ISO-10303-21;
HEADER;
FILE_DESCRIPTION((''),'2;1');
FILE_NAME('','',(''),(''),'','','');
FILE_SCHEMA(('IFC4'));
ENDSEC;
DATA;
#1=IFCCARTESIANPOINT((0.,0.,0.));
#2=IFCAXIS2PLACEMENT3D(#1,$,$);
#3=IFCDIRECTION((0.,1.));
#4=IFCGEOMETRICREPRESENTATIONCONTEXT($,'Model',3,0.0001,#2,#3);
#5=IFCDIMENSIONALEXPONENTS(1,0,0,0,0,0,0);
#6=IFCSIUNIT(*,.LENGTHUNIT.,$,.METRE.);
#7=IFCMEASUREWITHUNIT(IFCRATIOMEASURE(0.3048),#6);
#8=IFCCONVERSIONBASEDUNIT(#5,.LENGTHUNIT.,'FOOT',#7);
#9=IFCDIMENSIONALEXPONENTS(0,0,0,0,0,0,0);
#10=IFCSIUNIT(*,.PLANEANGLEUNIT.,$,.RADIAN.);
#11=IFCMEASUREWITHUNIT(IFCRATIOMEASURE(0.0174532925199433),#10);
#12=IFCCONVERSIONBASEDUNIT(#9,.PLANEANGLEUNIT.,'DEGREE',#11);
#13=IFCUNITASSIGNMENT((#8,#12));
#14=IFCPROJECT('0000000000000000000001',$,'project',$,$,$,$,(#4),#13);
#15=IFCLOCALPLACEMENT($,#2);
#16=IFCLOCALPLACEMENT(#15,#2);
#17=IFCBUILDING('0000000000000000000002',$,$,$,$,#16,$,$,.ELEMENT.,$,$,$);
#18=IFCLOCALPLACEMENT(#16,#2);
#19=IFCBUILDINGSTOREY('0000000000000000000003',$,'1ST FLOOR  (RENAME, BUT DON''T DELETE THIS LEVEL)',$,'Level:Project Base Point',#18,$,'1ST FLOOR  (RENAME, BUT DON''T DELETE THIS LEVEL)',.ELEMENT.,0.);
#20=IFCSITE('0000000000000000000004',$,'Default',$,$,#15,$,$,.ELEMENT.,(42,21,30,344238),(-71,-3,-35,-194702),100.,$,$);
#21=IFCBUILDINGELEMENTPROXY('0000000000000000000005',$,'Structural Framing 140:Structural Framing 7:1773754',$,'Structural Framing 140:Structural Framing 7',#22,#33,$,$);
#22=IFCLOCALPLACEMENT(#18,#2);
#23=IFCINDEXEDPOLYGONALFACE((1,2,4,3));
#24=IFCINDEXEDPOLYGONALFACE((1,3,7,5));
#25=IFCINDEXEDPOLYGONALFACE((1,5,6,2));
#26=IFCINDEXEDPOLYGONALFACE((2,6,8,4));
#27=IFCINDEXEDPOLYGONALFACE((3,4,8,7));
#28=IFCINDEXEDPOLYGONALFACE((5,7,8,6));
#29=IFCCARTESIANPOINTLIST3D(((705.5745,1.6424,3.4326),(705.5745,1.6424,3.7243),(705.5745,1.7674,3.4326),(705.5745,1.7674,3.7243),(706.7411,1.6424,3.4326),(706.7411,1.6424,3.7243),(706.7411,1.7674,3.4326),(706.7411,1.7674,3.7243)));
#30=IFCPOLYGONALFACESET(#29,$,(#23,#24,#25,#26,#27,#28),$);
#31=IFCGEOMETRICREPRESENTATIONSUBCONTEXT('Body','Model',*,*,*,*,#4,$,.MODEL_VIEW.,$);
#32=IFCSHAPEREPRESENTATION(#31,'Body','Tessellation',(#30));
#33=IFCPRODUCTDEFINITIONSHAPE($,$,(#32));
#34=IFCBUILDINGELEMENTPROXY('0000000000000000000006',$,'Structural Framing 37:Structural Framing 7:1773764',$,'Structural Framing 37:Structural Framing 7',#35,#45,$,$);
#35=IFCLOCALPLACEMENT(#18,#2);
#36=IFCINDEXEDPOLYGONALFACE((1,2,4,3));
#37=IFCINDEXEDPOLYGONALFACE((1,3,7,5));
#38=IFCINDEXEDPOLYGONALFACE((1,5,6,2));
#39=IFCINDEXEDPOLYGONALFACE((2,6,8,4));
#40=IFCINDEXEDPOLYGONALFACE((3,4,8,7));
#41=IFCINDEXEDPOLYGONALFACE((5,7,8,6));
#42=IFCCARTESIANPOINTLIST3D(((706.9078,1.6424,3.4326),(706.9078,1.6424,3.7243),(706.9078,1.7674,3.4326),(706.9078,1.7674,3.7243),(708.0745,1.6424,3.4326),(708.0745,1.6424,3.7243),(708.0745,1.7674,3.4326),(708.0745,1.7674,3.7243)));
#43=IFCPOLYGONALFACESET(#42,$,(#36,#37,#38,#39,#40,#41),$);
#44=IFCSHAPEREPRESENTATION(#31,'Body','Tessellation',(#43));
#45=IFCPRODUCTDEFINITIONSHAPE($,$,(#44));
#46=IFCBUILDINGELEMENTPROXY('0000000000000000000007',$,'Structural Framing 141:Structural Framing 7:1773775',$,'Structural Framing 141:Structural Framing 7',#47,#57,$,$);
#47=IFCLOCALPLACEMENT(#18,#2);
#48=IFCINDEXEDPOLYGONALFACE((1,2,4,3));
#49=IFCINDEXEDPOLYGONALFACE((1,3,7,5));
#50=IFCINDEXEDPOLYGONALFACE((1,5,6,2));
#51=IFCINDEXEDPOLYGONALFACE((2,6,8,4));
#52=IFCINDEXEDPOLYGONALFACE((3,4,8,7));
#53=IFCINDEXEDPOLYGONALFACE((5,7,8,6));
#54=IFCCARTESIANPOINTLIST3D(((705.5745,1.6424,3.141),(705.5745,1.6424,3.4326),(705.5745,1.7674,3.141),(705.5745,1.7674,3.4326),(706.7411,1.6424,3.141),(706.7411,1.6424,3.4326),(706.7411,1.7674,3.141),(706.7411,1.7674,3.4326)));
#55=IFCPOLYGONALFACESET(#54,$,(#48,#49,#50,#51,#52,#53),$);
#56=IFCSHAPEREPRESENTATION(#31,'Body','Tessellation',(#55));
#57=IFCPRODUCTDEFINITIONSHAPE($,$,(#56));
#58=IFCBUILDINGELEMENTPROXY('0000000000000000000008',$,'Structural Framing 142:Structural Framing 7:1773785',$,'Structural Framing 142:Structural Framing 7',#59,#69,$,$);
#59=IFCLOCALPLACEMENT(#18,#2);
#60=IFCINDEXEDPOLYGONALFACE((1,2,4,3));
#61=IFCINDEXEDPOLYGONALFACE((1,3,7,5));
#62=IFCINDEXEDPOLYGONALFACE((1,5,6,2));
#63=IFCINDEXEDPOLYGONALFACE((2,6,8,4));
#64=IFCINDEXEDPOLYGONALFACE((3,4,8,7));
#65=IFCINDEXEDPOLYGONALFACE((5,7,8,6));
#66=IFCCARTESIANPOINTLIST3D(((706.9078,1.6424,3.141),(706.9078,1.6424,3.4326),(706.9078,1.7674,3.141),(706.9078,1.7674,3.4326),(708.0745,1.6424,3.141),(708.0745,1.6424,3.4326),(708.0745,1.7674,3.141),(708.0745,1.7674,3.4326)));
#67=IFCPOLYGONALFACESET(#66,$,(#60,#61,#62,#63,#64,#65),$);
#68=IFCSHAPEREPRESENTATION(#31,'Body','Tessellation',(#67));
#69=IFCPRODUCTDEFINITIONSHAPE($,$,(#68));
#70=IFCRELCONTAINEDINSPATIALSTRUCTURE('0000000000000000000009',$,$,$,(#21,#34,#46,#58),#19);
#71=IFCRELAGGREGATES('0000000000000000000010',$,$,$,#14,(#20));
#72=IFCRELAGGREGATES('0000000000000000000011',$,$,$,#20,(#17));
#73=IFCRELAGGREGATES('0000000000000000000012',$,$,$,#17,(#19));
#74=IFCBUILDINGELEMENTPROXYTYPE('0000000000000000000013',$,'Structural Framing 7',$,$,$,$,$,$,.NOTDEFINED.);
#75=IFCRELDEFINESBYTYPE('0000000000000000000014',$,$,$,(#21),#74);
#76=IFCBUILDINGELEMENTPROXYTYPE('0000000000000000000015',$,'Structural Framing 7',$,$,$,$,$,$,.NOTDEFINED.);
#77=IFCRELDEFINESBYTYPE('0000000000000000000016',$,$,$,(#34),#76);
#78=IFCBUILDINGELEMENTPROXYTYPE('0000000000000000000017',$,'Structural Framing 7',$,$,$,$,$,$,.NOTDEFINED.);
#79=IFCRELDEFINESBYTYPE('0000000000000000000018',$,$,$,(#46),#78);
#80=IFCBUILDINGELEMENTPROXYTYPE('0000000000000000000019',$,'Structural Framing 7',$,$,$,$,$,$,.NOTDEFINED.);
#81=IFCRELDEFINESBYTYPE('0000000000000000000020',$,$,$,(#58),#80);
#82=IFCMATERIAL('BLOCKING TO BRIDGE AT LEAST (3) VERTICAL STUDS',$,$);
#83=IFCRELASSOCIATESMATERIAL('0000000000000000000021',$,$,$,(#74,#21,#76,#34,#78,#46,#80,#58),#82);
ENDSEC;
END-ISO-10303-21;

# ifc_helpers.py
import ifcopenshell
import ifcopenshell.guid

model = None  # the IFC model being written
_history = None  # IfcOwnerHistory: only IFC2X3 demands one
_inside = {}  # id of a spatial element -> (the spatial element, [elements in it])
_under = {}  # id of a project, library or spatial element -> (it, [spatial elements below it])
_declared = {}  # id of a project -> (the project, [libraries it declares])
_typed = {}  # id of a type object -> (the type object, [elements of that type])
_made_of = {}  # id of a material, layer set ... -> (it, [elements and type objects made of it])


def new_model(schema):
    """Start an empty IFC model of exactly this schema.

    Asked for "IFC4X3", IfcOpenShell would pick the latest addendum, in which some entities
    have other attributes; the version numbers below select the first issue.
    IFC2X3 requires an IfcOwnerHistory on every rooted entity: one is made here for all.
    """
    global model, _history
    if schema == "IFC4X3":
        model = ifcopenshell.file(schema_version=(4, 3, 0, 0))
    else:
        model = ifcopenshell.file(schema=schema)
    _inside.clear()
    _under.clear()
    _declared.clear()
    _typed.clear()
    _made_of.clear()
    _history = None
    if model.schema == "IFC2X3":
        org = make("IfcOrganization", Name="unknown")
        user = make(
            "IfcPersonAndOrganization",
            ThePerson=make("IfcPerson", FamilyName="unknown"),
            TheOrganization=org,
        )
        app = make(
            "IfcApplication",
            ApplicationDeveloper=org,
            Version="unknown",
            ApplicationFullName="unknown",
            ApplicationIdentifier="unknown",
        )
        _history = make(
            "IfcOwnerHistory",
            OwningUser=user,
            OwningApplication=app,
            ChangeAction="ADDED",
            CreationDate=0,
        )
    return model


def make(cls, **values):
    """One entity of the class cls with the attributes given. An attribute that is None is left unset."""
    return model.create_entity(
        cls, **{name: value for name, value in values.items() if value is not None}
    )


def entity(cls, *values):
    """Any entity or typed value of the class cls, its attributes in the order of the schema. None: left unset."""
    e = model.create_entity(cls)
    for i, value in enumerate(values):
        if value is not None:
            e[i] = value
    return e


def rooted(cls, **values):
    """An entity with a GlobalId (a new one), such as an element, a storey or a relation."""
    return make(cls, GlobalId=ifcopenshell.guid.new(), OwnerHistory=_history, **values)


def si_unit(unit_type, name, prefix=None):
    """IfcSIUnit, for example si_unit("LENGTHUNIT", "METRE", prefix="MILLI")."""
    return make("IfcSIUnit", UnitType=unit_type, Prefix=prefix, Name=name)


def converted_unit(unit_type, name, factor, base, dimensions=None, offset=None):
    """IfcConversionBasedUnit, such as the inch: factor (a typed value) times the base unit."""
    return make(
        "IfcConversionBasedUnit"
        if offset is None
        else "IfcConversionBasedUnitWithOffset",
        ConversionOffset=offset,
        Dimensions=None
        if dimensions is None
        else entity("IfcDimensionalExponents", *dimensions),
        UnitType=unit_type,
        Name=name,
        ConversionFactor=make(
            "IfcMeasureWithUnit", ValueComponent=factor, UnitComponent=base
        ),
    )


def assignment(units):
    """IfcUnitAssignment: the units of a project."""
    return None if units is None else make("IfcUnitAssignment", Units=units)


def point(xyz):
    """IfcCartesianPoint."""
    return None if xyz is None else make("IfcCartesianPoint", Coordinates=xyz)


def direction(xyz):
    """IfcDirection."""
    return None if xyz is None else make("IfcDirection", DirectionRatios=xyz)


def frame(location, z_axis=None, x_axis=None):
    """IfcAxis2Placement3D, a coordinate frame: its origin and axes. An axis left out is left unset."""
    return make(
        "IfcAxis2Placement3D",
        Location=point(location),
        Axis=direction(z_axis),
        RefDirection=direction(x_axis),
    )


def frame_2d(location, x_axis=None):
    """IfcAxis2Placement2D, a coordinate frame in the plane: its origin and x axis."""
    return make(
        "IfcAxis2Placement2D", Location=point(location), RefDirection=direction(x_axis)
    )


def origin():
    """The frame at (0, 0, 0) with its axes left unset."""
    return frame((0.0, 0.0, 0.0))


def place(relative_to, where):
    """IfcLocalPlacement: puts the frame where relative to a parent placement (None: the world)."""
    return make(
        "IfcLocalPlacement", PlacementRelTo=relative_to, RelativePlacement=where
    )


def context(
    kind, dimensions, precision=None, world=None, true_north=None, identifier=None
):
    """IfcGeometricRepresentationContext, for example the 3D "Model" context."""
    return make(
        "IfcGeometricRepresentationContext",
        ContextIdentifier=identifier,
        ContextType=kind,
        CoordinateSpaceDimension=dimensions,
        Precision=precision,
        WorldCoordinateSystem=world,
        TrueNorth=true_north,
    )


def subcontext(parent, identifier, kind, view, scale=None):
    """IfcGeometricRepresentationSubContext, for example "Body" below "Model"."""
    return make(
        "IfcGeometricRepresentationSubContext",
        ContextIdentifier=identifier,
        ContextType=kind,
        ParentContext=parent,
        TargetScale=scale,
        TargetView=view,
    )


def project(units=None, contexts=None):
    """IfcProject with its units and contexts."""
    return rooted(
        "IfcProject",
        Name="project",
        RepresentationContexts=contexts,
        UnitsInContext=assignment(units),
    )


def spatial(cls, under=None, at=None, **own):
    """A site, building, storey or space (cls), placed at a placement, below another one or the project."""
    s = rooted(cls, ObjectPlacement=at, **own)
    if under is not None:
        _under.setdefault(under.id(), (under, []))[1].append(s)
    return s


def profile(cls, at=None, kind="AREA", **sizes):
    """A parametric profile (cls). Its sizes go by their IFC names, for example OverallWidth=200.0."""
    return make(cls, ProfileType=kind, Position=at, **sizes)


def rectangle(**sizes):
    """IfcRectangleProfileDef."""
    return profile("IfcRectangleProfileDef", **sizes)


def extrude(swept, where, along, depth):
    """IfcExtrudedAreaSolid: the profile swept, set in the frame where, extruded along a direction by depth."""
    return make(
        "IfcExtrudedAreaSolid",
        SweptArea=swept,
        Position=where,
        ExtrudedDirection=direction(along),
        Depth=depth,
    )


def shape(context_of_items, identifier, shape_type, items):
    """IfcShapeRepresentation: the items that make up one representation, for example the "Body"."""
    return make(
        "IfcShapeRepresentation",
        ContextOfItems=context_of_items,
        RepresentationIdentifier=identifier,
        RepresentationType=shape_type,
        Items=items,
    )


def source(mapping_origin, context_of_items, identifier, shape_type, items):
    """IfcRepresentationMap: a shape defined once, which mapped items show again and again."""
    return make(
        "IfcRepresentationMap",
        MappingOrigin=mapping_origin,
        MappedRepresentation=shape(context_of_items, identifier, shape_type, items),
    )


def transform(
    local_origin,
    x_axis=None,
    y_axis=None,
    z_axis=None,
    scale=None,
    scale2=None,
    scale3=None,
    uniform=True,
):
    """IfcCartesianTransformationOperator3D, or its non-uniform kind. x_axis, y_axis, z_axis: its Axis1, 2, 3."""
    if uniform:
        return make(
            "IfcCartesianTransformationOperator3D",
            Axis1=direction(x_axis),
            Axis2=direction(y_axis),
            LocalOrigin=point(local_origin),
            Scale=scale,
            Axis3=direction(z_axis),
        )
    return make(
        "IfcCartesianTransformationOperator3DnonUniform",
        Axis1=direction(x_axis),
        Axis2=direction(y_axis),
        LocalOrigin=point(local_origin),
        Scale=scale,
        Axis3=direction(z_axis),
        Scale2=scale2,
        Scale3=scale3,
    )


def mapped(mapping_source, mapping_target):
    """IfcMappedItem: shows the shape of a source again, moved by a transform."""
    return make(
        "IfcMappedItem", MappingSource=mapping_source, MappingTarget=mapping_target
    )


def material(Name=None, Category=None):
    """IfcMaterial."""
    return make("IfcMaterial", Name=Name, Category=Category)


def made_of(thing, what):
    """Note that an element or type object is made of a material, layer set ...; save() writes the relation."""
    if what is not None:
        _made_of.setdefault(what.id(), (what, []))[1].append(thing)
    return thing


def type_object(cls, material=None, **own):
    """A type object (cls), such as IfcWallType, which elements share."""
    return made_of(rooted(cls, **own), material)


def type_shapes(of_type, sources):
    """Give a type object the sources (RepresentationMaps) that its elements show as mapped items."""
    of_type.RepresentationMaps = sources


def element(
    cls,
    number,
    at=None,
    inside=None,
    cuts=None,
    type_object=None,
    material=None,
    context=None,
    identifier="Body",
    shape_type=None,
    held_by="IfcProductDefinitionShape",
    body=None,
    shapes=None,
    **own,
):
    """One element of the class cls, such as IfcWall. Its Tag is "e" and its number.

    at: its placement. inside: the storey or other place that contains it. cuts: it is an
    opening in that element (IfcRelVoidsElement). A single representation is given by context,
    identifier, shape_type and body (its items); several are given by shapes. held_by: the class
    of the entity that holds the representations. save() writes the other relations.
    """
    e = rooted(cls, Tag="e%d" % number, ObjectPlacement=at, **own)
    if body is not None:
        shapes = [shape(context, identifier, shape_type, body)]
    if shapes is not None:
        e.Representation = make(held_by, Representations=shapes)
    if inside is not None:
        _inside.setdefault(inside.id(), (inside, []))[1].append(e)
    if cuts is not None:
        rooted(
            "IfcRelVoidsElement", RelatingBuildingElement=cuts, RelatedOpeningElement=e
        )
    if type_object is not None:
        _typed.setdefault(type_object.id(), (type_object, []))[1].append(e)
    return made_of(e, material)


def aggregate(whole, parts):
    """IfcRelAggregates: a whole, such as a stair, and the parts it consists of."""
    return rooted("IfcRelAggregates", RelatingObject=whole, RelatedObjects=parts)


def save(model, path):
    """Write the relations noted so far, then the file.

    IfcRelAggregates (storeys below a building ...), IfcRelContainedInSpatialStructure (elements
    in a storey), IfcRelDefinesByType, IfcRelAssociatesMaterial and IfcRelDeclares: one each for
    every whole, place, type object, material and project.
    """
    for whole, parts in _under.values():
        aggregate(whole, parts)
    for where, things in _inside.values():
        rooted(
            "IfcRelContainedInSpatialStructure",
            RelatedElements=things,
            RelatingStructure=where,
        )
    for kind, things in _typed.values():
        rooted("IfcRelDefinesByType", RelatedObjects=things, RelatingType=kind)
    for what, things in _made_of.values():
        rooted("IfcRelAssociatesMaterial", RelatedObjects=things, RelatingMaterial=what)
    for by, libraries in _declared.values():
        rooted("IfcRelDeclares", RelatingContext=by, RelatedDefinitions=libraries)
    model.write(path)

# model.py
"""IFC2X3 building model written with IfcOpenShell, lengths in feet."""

from ifc_helpers import new_model, entity, si_unit, converted_unit, direction, frame, frame_2d, origin, place, context, subcontext, project, spatial, rectangle, extrude, source, transform, mapped, material, type_object, type_shapes, element, save


model = new_model("IFC2X3")

# Units and contexts
model_context = context("Model", 3, precision=0.0001, world=origin(), true_north=direction((0.0, 1.0)))
body_context = subcontext(model_context, "Body", "Model", "MODEL_VIEW")
ifc_project = project(units=[converted_unit("LENGTHUNIT", "FOOT", entity("IfcRatioMeasure", 0.3048), si_unit("LENGTHUNIT", "METRE"), dimensions=[1, 0, 0, 0, 0, 0, 0]), converted_unit("PLANEANGLEUNIT", "DEGREE", entity("IfcRatioMeasure", 0.0174532925199433), si_unit("PLANEANGLEUNIT", "RADIAN"), dimensions=[0, 0, 0, 0, 0, 0, 0])], contexts=[model_context])

# Site, building, storey
site_placement = place(None, origin())
site = spatial("IfcSite", under=ifc_project, at=site_placement, Name="Default", CompositionType="ELEMENT", RefLatitude=(42, 21, 30, 344238), RefLongitude=(-71, -3, -35, -194702), RefElevation=100.0)
building_placement = place(site_placement, origin())
building = spatial("IfcBuilding", under=site, at=building_placement, CompositionType="ELEMENT")
storey_placement = place(building_placement, origin())
storey = spatial("IfcBuildingStorey", under=building, at=storey_placement, Name="1ST FLOOR  (RENAME, BUT DON'T DELETE THIS LEVEL)", ObjectType="Level:Project Base Point", LongName="1ST FLOOR  (RENAME, BUT DON'T DELETE THIS LEVEL)", CompositionType="ELEMENT", Elevation=0.0)

# Building element proxies
ifc_material_1 = material(Name="BLOCKING TO BRIDGE AT LEAST (3) VERTICAL STUDS")
building_element_proxy_type_1 = type_object("IfcBuildingElementProxyType", Name="Structural Framing 7", PredefinedType="NOTDEFINED", material=ifc_material_1)
shared_shape_1 = source(origin(), body_context, "Body", "SweptSolid", [
    extrude(rectangle(XDim=1.1667, YDim=0.125, at=frame_2d((0.0, 0.0), x_axis=(1.0, 0.0))), frame((0.5833, 0.0625, 0.0), z_axis=(0.0, 0.0, 1.0), x_axis=(-1.0, 0.0, 0.0)), (0.0, 0.0, 1.0), 0.2917),
])
type_shapes(building_element_proxy_type_1, [shared_shape_1])
proxy_1_placement = place(storey_placement, frame((705.5745, 1.6424, 3.4326)))
element("IfcBuildingElementProxy", 1, at=proxy_1_placement, inside=storey, type_object=building_element_proxy_type_1, material=ifc_material_1, Name="Structural Framing 140:Structural Framing 7:1773754", ObjectType="Structural Framing 140:Structural Framing 7", context=body_context, shape_type="MappedRepresentation", body=[
    mapped(shared_shape_1, transform((0.0, 0.0, 0.0), scale=1.0)),
])
building_element_proxy_type_2 = type_object("IfcBuildingElementProxyType", Name="Structural Framing 7", PredefinedType="NOTDEFINED", material=ifc_material_1)
shared_shape_2 = source(origin(), body_context, "Body", "SweptSolid", [
    extrude(rectangle(XDim=1.1667, YDim=0.125, at=frame_2d((0.0, 0.0), x_axis=(1.0, 0.0))), frame((0.5833, 0.0625, 0.0), z_axis=(0.0, 0.0, 1.0), x_axis=(-1.0, 0.0, 0.0)), (0.0, 0.0, 1.0), 0.2917),
])
type_shapes(building_element_proxy_type_2, [shared_shape_2])
proxy_2_placement = place(storey_placement, frame((706.9078, 1.6424, 3.4326)))
element("IfcBuildingElementProxy", 2, at=proxy_2_placement, inside=storey, type_object=building_element_proxy_type_2, material=ifc_material_1, Name="Structural Framing 37:Structural Framing 7:1773764", ObjectType="Structural Framing 37:Structural Framing 7", context=body_context, shape_type="MappedRepresentation", body=[
    mapped(shared_shape_2, transform((0.0, 0.0, 0.0), scale=1.0)),
])
building_element_proxy_type_3 = type_object("IfcBuildingElementProxyType", Name="Structural Framing 7", PredefinedType="NOTDEFINED", material=ifc_material_1)
shared_shape_3 = source(origin(), body_context, "Body", "SweptSolid", [
    extrude(rectangle(XDim=1.1667, YDim=0.125, at=frame_2d((0.0, 0.0), x_axis=(1.0, 0.0))), frame((0.5833, 0.0625, 0.0), z_axis=(0.0, 0.0, 1.0), x_axis=(-1.0, 0.0, 0.0)), (0.0, 0.0, 1.0), 0.2917),
])
type_shapes(building_element_proxy_type_3, [shared_shape_3])
proxy_3_placement = place(storey_placement, frame((705.5745, 1.6424, 3.141)))
element("IfcBuildingElementProxy", 3, at=proxy_3_placement, inside=storey, type_object=building_element_proxy_type_3, material=ifc_material_1, Name="Structural Framing 141:Structural Framing 7:1773775", ObjectType="Structural Framing 141:Structural Framing 7", context=body_context, shape_type="MappedRepresentation", body=[
    mapped(shared_shape_3, transform((0.0, 0.0, 0.0), scale=1.0)),
])
building_element_proxy_type_4 = type_object("IfcBuildingElementProxyType", Name="Structural Framing 7", PredefinedType="NOTDEFINED", material=ifc_material_1)
shared_shape_4 = source(origin(), body_context, "Body", "SweptSolid", [
    extrude(rectangle(XDim=1.1667, YDim=0.125, at=frame_2d((0.0, 0.0), x_axis=(1.0, 0.0))), frame((0.5833, 0.0625, 0.0), z_axis=(0.0, 0.0, 1.0), x_axis=(-1.0, 0.0, 0.0)), (0.0, 0.0, 1.0), 0.2917),
])
type_shapes(building_element_proxy_type_4, [shared_shape_4])
proxy_4_placement = place(storey_placement, frame((706.9078, 1.6424, 3.141)))
element("IfcBuildingElementProxy", 4, at=proxy_4_placement, inside=storey, type_object=building_element_proxy_type_4, material=ifc_material_1, Name="Structural Framing 142:Structural Framing 7:1773785", ObjectType="Structural Framing 142:Structural Framing 7", context=body_context, shape_type="MappedRepresentation", body=[
    mapped(shared_shape_4, transform((0.0, 0.0, 0.0), scale=1.0)),
])

save(model, "model.ifc")
